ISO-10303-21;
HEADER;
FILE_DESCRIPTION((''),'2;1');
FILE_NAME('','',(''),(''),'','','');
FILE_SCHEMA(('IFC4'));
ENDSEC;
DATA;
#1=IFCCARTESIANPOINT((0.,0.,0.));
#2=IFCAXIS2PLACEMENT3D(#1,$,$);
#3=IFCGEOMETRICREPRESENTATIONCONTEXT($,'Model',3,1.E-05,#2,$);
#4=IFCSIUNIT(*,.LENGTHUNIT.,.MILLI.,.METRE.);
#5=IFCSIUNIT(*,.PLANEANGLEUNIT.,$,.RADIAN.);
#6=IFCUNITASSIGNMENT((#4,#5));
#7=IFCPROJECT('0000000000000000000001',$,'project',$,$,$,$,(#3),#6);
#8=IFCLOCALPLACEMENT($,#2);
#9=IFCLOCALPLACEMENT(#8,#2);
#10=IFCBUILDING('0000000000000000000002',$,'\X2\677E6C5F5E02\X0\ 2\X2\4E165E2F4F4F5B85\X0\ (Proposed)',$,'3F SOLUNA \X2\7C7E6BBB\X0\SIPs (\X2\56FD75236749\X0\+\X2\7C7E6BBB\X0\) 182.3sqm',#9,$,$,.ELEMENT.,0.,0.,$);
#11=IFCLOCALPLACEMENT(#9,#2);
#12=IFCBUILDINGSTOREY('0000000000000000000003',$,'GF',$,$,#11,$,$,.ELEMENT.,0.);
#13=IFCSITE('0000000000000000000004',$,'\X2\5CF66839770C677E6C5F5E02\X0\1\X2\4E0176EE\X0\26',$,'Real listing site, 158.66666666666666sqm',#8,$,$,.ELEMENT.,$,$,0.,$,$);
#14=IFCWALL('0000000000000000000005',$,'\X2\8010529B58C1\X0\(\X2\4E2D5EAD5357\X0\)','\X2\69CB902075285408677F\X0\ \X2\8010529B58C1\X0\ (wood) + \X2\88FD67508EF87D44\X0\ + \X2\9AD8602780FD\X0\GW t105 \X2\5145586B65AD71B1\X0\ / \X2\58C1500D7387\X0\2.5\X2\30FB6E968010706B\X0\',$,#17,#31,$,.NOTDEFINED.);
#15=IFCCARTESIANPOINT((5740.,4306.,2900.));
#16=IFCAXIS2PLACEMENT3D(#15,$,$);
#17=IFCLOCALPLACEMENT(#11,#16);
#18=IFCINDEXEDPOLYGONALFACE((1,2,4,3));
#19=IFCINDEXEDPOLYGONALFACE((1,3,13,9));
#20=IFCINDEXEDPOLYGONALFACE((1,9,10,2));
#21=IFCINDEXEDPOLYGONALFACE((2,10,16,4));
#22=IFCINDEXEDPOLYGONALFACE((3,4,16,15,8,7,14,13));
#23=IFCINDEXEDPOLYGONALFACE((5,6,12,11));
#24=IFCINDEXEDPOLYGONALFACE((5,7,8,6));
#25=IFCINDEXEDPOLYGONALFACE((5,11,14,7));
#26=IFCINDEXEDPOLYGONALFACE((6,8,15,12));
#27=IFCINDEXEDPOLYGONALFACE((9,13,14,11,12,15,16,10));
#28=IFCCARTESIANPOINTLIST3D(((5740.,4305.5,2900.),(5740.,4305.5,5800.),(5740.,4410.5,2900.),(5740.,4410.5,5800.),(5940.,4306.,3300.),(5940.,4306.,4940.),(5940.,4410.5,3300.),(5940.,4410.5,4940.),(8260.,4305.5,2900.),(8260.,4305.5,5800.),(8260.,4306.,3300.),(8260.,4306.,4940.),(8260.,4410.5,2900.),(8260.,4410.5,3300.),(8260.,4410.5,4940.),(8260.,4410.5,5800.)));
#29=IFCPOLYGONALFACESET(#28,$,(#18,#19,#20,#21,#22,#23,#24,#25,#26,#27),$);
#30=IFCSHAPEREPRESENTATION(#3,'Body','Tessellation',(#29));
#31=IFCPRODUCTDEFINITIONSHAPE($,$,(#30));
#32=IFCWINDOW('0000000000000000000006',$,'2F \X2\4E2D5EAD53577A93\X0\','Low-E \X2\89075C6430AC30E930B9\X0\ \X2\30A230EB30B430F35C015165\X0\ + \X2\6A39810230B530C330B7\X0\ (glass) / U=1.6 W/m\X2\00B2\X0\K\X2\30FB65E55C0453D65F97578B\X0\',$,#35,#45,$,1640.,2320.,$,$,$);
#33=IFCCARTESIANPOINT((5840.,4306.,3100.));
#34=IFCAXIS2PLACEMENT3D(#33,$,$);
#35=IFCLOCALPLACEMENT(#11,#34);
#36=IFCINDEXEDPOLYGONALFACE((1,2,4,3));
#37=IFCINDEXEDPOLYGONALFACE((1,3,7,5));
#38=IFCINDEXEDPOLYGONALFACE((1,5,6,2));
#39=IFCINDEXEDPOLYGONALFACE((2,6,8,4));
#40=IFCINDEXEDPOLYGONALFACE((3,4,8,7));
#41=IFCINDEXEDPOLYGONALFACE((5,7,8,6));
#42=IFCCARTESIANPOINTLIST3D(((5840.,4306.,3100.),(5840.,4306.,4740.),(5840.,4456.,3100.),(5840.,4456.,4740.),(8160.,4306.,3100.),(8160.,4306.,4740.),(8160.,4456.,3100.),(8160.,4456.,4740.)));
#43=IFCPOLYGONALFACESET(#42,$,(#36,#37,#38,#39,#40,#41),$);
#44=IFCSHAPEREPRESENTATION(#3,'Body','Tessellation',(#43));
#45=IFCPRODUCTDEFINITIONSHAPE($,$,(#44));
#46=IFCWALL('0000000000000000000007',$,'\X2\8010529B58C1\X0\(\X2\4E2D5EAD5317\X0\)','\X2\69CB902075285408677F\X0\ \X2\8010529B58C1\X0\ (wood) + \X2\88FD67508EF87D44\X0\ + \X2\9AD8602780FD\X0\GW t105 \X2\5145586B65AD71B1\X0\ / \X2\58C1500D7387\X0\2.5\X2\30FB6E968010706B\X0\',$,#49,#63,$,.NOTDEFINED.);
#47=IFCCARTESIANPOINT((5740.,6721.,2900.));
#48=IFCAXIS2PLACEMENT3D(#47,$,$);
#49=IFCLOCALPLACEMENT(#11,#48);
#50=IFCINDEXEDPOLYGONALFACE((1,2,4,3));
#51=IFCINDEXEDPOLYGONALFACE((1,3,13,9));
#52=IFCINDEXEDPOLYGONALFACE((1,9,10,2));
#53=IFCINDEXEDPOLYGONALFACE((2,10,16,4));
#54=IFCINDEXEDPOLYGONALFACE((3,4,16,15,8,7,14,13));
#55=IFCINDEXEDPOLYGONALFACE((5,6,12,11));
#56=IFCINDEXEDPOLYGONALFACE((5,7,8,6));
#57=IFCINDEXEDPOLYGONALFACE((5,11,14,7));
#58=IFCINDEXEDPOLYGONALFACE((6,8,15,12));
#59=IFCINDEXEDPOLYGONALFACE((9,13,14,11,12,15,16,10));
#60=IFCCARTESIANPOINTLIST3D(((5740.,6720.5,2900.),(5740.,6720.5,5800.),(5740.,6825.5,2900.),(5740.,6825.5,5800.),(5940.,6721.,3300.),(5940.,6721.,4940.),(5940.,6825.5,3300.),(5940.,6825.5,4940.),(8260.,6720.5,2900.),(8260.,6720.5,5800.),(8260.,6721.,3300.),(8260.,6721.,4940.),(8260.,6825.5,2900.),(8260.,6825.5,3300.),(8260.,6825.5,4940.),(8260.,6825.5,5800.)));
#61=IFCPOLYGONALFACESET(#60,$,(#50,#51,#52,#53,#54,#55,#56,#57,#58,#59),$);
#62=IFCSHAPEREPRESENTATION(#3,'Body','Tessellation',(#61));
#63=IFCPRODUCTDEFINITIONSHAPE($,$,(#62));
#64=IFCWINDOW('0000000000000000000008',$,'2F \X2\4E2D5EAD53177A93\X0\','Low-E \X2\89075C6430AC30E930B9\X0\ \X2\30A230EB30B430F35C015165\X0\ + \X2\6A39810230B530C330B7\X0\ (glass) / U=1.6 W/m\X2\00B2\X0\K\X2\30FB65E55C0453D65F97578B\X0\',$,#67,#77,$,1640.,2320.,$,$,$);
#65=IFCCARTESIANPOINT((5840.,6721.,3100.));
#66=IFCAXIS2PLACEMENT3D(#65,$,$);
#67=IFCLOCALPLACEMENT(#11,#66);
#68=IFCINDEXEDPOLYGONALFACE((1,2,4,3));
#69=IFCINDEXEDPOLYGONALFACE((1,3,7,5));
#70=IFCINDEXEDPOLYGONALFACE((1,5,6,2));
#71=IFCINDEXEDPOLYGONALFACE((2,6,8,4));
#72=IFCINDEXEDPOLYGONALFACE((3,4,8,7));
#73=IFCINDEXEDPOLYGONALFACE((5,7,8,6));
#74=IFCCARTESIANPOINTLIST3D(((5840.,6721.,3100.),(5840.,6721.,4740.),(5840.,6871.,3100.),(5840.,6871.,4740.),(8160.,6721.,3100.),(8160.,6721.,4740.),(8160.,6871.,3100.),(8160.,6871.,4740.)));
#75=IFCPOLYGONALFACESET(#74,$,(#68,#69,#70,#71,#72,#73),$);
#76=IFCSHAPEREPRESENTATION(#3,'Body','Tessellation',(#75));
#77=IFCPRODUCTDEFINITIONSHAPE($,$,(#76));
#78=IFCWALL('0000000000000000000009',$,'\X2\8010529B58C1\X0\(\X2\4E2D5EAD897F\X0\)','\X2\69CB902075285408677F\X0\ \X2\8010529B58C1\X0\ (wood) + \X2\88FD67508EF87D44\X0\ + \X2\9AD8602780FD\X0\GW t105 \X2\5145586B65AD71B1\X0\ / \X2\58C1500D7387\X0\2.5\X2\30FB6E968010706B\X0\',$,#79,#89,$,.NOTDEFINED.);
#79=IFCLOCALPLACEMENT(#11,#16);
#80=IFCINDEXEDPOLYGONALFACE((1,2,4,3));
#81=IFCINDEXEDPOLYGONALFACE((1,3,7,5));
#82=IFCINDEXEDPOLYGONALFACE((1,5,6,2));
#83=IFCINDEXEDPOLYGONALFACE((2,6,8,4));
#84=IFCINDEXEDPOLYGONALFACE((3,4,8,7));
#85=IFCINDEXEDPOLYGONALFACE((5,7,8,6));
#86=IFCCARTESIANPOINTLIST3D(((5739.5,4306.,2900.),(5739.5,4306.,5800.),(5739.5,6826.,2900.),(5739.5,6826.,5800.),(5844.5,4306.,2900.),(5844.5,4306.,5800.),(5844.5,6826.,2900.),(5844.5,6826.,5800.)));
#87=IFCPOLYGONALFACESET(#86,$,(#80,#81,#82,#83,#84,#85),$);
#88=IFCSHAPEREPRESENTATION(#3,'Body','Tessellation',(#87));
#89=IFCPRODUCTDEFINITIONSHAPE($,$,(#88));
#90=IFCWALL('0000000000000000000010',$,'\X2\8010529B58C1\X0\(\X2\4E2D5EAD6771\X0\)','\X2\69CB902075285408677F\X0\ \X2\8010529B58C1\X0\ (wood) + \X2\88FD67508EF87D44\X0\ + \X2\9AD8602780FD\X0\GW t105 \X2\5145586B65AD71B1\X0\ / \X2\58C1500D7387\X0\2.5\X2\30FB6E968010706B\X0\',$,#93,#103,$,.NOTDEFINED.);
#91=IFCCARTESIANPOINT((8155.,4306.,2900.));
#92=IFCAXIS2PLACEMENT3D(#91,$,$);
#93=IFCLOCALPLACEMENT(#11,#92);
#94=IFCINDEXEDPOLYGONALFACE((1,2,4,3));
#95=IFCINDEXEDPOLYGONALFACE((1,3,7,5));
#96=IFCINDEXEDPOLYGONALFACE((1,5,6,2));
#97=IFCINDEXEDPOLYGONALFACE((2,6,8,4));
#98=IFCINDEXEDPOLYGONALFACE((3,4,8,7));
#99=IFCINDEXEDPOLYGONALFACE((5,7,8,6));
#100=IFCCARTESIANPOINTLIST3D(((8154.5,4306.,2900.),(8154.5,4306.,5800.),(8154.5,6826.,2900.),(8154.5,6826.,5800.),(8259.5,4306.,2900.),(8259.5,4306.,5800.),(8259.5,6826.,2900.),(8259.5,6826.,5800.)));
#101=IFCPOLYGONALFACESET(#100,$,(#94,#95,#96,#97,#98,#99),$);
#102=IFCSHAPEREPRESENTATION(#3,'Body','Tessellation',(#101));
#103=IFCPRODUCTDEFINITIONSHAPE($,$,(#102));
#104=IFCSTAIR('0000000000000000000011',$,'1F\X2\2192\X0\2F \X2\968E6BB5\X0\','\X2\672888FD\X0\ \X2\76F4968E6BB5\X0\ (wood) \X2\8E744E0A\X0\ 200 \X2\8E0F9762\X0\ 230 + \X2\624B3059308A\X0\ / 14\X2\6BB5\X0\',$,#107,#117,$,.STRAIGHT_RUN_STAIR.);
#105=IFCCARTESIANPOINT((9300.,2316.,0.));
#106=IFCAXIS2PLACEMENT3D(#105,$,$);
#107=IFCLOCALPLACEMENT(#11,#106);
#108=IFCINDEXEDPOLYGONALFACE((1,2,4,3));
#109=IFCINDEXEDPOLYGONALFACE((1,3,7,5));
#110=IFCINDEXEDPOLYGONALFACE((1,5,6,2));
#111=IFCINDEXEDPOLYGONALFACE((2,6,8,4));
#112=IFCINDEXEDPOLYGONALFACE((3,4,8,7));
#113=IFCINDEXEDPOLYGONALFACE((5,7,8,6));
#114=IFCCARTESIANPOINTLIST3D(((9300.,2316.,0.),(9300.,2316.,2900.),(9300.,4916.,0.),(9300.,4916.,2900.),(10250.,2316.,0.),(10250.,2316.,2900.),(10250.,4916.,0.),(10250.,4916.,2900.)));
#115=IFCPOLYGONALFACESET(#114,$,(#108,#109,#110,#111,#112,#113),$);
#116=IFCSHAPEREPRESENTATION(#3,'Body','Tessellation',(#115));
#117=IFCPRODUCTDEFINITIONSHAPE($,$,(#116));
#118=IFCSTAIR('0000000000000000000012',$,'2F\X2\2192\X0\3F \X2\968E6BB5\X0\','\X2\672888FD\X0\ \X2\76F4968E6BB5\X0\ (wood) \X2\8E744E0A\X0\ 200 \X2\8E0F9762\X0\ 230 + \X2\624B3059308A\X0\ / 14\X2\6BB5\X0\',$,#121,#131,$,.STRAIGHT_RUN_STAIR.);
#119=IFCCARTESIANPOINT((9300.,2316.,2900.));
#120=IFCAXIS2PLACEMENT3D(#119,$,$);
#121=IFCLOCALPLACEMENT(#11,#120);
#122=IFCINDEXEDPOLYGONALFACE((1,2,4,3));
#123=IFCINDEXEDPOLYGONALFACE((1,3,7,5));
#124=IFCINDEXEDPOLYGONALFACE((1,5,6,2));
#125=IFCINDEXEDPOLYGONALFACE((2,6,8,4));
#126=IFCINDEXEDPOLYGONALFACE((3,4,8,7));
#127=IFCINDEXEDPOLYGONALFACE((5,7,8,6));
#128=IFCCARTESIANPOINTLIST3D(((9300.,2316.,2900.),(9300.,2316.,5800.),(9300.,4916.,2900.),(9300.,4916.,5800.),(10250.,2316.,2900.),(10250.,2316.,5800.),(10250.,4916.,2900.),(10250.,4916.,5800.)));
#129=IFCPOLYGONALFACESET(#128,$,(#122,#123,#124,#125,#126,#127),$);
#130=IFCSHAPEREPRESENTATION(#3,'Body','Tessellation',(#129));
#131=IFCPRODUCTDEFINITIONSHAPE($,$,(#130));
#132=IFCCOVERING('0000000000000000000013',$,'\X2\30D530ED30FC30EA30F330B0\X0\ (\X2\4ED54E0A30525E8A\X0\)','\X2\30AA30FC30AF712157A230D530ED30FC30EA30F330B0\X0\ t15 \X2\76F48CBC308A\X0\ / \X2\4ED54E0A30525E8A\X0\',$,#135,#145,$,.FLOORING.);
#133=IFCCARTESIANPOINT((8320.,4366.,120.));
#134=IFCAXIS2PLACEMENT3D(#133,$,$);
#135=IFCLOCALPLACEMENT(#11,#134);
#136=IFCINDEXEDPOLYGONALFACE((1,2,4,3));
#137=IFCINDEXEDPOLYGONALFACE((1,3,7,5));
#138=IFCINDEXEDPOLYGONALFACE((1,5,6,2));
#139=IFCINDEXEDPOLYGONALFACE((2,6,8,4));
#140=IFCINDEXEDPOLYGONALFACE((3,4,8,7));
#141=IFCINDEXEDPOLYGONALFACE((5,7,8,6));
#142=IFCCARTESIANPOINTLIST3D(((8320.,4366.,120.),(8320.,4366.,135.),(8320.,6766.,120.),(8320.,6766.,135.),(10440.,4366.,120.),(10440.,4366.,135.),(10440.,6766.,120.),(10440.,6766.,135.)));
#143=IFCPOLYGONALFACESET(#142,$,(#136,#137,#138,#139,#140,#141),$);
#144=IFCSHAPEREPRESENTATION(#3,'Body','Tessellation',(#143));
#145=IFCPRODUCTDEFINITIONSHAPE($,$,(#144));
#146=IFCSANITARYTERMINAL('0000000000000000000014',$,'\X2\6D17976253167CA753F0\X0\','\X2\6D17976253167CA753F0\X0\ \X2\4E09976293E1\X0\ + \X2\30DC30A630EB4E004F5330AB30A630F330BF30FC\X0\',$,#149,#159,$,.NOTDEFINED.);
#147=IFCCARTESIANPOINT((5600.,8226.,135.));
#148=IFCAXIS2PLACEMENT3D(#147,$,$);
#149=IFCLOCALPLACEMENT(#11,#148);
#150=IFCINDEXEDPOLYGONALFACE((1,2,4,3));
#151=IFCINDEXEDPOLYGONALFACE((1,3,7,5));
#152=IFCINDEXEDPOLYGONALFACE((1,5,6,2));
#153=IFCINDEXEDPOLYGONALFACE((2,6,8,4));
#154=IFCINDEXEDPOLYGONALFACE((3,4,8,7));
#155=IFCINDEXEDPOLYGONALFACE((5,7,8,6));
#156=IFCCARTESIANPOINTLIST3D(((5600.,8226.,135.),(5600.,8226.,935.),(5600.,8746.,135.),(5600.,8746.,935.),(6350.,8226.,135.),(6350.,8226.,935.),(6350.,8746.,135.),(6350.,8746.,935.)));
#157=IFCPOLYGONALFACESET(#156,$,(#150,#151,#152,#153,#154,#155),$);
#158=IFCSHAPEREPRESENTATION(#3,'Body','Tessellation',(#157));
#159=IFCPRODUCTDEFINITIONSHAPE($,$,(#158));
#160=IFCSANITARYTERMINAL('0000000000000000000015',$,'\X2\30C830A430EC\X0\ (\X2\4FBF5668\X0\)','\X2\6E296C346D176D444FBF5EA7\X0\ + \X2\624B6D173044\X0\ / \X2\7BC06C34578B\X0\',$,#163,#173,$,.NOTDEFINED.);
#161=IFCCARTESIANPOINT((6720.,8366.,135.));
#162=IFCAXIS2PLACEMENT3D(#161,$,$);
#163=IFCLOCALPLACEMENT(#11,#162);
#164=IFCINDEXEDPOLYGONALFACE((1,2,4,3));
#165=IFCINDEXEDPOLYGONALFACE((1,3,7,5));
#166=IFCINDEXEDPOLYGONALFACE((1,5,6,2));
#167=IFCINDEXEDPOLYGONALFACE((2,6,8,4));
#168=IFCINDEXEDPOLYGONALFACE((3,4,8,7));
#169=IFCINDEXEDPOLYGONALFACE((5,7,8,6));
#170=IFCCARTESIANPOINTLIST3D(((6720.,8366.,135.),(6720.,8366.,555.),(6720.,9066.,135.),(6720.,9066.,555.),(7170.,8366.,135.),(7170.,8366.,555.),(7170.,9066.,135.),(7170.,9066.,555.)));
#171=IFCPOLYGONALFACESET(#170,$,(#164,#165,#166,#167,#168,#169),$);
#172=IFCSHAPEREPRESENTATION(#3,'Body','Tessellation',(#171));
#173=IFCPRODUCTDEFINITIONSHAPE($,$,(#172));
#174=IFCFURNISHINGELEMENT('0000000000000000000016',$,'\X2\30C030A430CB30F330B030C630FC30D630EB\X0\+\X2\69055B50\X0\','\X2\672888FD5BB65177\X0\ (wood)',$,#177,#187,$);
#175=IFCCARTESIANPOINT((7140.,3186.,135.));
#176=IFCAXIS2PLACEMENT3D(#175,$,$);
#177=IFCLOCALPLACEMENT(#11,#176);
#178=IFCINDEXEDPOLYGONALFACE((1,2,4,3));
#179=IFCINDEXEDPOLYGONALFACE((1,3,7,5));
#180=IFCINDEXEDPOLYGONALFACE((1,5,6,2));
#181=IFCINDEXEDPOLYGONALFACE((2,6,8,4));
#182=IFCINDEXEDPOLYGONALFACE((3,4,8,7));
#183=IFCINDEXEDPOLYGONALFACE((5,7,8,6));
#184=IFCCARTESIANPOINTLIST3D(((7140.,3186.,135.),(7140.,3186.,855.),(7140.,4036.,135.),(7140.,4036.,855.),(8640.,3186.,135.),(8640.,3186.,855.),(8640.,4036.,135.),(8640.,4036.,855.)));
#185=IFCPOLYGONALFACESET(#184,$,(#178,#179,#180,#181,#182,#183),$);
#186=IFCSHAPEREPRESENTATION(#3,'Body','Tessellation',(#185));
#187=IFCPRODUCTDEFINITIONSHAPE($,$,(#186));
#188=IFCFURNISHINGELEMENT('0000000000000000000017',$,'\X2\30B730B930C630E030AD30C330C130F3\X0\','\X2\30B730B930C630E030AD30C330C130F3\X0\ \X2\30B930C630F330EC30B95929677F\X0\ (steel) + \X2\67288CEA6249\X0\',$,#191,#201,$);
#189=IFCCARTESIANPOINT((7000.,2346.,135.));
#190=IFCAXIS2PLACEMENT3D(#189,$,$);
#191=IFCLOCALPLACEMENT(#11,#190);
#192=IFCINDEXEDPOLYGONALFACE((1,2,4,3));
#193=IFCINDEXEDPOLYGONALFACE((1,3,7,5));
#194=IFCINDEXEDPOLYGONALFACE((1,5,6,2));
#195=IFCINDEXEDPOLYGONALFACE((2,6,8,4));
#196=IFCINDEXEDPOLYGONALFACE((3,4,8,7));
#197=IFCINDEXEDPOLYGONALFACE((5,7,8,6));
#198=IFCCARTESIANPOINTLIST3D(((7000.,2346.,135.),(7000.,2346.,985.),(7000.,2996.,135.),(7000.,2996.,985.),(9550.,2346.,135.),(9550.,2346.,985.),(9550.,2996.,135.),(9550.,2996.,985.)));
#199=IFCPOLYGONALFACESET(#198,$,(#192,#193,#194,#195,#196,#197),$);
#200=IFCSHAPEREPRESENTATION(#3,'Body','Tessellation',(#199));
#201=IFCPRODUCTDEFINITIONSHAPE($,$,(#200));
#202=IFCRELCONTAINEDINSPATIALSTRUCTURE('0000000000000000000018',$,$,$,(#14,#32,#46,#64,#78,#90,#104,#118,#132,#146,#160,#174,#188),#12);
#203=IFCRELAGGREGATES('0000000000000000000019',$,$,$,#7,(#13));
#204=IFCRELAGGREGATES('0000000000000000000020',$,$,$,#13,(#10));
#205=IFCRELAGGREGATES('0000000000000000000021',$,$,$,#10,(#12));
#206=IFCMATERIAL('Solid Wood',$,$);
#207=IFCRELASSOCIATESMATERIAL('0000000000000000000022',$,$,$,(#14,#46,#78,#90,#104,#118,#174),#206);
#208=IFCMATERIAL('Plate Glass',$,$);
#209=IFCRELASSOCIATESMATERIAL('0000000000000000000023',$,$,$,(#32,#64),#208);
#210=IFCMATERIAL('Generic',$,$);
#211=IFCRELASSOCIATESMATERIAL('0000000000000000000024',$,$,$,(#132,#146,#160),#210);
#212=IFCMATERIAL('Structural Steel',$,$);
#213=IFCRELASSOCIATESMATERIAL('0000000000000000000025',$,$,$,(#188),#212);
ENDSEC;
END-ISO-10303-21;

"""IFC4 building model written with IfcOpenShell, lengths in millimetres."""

from ifc_helpers import new_model, si_unit, frame, frame_2d, origin, place, context, project, spatial, rectangle, extrude, material, element, fill, save


model = new_model("IFC4")

# Units and contexts
model_context = context("Model", 3, precision=1e-05, world=origin())
ifc_project = project(units=[si_unit("LENGTHUNIT", "METRE", prefix="MILLI"), si_unit("PLANEANGLEUNIT", "RADIAN")], contexts=[model_context])

# Site, building, storey
site_placement = place(None, origin())
site = spatial("IfcSite", under=ifc_project, at=site_placement, Name="島根県松江市1丁目26", ObjectType="Real listing site, 158.66666666666666sqm", CompositionType="ELEMENT", RefElevation=0.0)
building_placement = place(site_placement, origin())
building = spatial("IfcBuilding", under=site, at=building_placement, Name="松江市 2世帯住宅 (Proposed)", ObjectType="3F SOLUNA 籾殻SIPs (国産杉+籾殻) 182.3sqm", CompositionType="ELEMENT", ElevationOfRefHeight=0.0, ElevationOfTerrain=0.0)
storey_placement = place(building_placement, origin())
storey = spatial("IfcBuildingStorey", under=building, at=storey_placement, Name="GF", CompositionType="ELEMENT", Elevation=0.0)

# Shared definitions
ifc_material_1 = material(Name="Solid Wood")

# Shared definitions
ifc_material_2 = material(Name="Plate Glass")

# Walls, openings, windows
wall_1_placement = place(storey_placement, frame((5740.0, 4306.0, 2900.0)))
wall_1 = element("IfcWall", 1, at=wall_1_placement, inside=storey, material=ifc_material_1, Name="耐力壁(中庭南)", Description="構造用合板 耐力壁 (wood) + 製材軸組 + 高性能GW t105 充填断熱 / 壁倍率2.5・準耐火", PredefinedType="NOTDEFINED", context=model_context, shape_type="SweptSolid", body=[
    extrude(rectangle(XDim=2520.0, YDim=105.0, at=frame_2d((1260.0, 52.0))), frame((5740.0, 4306.0, 2900.0)), (0.0, 0.0, 1.0), 2900.0),
])
opening_1_placement = place(storey_placement, frame((5840.0, 4306.0, 3100.0)))
opening_1 = element("IfcOpeningElement", 2, at=opening_1_placement, cuts=wall_1, PredefinedType="NOTDEFINED", context=model_context, shape_type="SweptSolid", body=[
    extrude(rectangle(XDim=2320.0, YDim=150.0, at=frame_2d((1160.0, 75.0))), frame((5840.0, 4306.0, 3100.0)), (0.0, 0.0, 1.0), 1640.0),
])
window_1_placement = place(storey_placement, frame((5840.0, 4306.0, 3100.0)))
window_1 = element("IfcWindow", 3, at=window_1_placement, inside=storey, material=ifc_material_2, Name="2F 中庭南窓", Description="Low-E 複層ガラス アルゴン封入 + 樹脂サッシ (glass) / U=1.6 W/m²K・日射取得型", OverallHeight=1640.0, OverallWidth=2320.0, context=model_context, shape_type="SweptSolid", body=[
    extrude(rectangle(XDim=2320.0, YDim=150.0, at=frame_2d((1160.0, 75.0))), frame((5840.0, 4306.0, 3100.0)), (0.0, 0.0, 1.0), 1640.0),
])
fill(opening_1, window_1)
wall_2_placement = place(storey_placement, frame((5740.0, 6721.0, 2900.0)))
wall_2 = element("IfcWall", 4, at=wall_2_placement, inside=storey, material=ifc_material_1, Name="耐力壁(中庭北)", Description="構造用合板 耐力壁 (wood) + 製材軸組 + 高性能GW t105 充填断熱 / 壁倍率2.5・準耐火", PredefinedType="NOTDEFINED", context=model_context, shape_type="SweptSolid", body=[
    extrude(rectangle(XDim=2520.0, YDim=105.0, at=frame_2d((1260.0, 52.0))), frame((5740.0, 6721.0, 2900.0)), (0.0, 0.0, 1.0), 2900.0),
])
opening_2_placement = place(storey_placement, frame((5840.0, 6721.0, 3100.0)))
opening_2 = element("IfcOpeningElement", 5, at=opening_2_placement, cuts=wall_2, PredefinedType="NOTDEFINED", context=model_context, shape_type="SweptSolid", body=[
    extrude(rectangle(XDim=2320.0, YDim=150.0, at=frame_2d((1160.0, 75.0))), frame((5840.0, 6721.0, 3100.0)), (0.0, 0.0, 1.0), 1640.0),
])
window_2_placement = place(storey_placement, frame((5840.0, 6721.0, 3100.0)))
window_2 = element("IfcWindow", 6, at=window_2_placement, inside=storey, material=ifc_material_2, Name="2F 中庭北窓", Description="Low-E 複層ガラス アルゴン封入 + 樹脂サッシ (glass) / U=1.6 W/m²K・日射取得型", OverallHeight=1640.0, OverallWidth=2320.0, context=model_context, shape_type="SweptSolid", body=[
    extrude(rectangle(XDim=2320.0, YDim=150.0, at=frame_2d((1160.0, 75.0))), frame((5840.0, 6721.0, 3100.0)), (0.0, 0.0, 1.0), 1640.0),
])
fill(opening_2, window_2)

# Walls
wall_3_placement = place(storey_placement, frame((5740.0, 4306.0, 2900.0)))
element("IfcWall", 7, at=wall_3_placement, inside=storey, material=ifc_material_1, Name="耐力壁(中庭西)", Description="構造用合板 耐力壁 (wood) + 製材軸組 + 高性能GW t105 充填断熱 / 壁倍率2.5・準耐火", PredefinedType="NOTDEFINED", context=model_context, shape_type="SweptSolid", body=[
    extrude(rectangle(XDim=105.0, YDim=2520.0, at=frame_2d((52.0, 1260.0))), frame((5740.0, 4306.0, 2900.0)), (0.0, 0.0, 1.0), 2900.0),
])
wall_4_placement = place(storey_placement, frame((8155.0, 4306.0, 2900.0)))
element("IfcWall", 8, at=wall_4_placement, inside=storey, material=ifc_material_1, Name="耐力壁(中庭東)", Description="構造用合板 耐力壁 (wood) + 製材軸組 + 高性能GW t105 充填断熱 / 壁倍率2.5・準耐火", PredefinedType="NOTDEFINED", context=model_context, shape_type="SweptSolid", body=[
    extrude(rectangle(XDim=105.0, YDim=2520.0, at=frame_2d((52.0, 1260.0))), frame((8155.0, 4306.0, 2900.0)), (0.0, 0.0, 1.0), 2900.0),
])

# Stairs
stair_1_placement = place(storey_placement, frame((9300.0, 2316.0, 0.0)))
element("IfcStair", 9, at=stair_1_placement, inside=storey, material=ifc_material_1, Name="1F→2F 階段", Description="木製 直階段 (wood) 蹴上 200 踏面 230 + 手すり / 14段", PredefinedType="STRAIGHT_RUN_STAIR", context=model_context, shape_type="SweptSolid", body=[
    extrude(rectangle(XDim=950.0, YDim=2600.0, at=frame_2d((475.0, 1300.0))), frame((9300.0, 2316.0, 0.0)), (0.0, 0.0, 1.0), 2900.0),
])
stair_2_placement = place(storey_placement, frame((9300.0, 2316.0, 2900.0)))
element("IfcStair", 10, at=stair_2_placement, inside=storey, material=ifc_material_1, Name="2F→3F 階段", Description="木製 直階段 (wood) 蹴上 200 踏面 230 + 手すり / 14段", PredefinedType="STRAIGHT_RUN_STAIR", context=model_context, shape_type="SweptSolid", body=[
    extrude(rectangle(XDim=950.0, YDim=2600.0, at=frame_2d((475.0, 1300.0))), frame((9300.0, 2316.0, 2900.0)), (0.0, 0.0, 1.0), 2900.0),
])

# Covering
ifc_material_3 = material(Name="Generic")
covering_placement = place(storey_placement, frame((8320.0, 4366.0, 120.0)))
element("IfcCovering", 11, at=covering_placement, inside=storey, material=ifc_material_3, Name="フローリング (仕上げ床)", Description="オーク無垢フローリング t15 直貼り / 仕上げ床", PredefinedType="FLOORING", context=model_context, shape_type="SweptSolid", body=[
    extrude(rectangle(XDim=2120.0, YDim=2400.0, at=frame_2d((1060.0, 1200.0))), frame((8320.0, 4366.0, 120.0)), (0.0, 0.0, 1.0), 15.0),
])

# Sanitary terminals
sanitary_terminal_1_placement = place(storey_placement, frame((5600.0, 8226.0, 135.0)))
element("IfcSanitaryTerminal", 12, at=sanitary_terminal_1_placement, inside=storey, material=ifc_material_3, Name="洗面化粧台", Description="洗面化粧台 三面鏡 + ボウル一体カウンター", PredefinedType="NOTDEFINED", context=model_context, shape_type="SweptSolid", body=[
    extrude(rectangle(XDim=750.0, YDim=520.0, at=frame_2d((375.0, 260.0))), frame((5600.0, 8226.0, 135.0)), (0.0, 0.0, 1.0), 800.0),
])
sanitary_terminal_2_placement = place(storey_placement, frame((6720.0, 8366.0, 135.0)))
element("IfcSanitaryTerminal", 13, at=sanitary_terminal_2_placement, inside=storey, material=ifc_material_3, Name="トイレ (便器)", Description="温水洗浄便座 + 手洗い / 節水型", PredefinedType="NOTDEFINED", context=model_context, shape_type="SweptSolid", body=[
    extrude(rectangle(XDim=450.0, YDim=700.0, at=frame_2d((225.0, 350.0))), frame((6720.0, 8366.0, 135.0)), (0.0, 0.0, 1.0), 420.0),
])

# Furnishing elements
furnishing_1_placement = place(storey_placement, frame((7140.0, 3186.0, 135.0)))
element("IfcFurnishingElement", 14, at=furnishing_1_placement, inside=storey, material=ifc_material_1, Name="ダイニングテーブル+椅子", Description="木製家具 (wood)", context=model_context, shape_type="SweptSolid", body=[
    extrude(rectangle(XDim=1500.0, YDim=850.0, at=frame_2d((750.0, 425.0))), frame((7140.0, 3186.0, 135.0)), (0.0, 0.0, 1.0), 720.0),
])
ifc_material_4 = material(Name="Structural Steel")
furnishing_2_placement = place(storey_placement, frame((7000.0, 2346.0, 135.0)))
element("IfcFurnishingElement", 15, at=furnishing_2_placement, inside=storey, material=ifc_material_4, Name="システムキッチン", Description="システムキッチン ステンレス天板 (steel) + 木質扉", context=model_context, shape_type="SweptSolid", body=[
    extrude(rectangle(XDim=2550.0, YDim=650.0, at=frame_2d((1275.0, 325.0))), frame((7000.0, 2346.0, 135.0)), (0.0, 0.0, 1.0), 850.0),
])

save(model, "model.ifc")
